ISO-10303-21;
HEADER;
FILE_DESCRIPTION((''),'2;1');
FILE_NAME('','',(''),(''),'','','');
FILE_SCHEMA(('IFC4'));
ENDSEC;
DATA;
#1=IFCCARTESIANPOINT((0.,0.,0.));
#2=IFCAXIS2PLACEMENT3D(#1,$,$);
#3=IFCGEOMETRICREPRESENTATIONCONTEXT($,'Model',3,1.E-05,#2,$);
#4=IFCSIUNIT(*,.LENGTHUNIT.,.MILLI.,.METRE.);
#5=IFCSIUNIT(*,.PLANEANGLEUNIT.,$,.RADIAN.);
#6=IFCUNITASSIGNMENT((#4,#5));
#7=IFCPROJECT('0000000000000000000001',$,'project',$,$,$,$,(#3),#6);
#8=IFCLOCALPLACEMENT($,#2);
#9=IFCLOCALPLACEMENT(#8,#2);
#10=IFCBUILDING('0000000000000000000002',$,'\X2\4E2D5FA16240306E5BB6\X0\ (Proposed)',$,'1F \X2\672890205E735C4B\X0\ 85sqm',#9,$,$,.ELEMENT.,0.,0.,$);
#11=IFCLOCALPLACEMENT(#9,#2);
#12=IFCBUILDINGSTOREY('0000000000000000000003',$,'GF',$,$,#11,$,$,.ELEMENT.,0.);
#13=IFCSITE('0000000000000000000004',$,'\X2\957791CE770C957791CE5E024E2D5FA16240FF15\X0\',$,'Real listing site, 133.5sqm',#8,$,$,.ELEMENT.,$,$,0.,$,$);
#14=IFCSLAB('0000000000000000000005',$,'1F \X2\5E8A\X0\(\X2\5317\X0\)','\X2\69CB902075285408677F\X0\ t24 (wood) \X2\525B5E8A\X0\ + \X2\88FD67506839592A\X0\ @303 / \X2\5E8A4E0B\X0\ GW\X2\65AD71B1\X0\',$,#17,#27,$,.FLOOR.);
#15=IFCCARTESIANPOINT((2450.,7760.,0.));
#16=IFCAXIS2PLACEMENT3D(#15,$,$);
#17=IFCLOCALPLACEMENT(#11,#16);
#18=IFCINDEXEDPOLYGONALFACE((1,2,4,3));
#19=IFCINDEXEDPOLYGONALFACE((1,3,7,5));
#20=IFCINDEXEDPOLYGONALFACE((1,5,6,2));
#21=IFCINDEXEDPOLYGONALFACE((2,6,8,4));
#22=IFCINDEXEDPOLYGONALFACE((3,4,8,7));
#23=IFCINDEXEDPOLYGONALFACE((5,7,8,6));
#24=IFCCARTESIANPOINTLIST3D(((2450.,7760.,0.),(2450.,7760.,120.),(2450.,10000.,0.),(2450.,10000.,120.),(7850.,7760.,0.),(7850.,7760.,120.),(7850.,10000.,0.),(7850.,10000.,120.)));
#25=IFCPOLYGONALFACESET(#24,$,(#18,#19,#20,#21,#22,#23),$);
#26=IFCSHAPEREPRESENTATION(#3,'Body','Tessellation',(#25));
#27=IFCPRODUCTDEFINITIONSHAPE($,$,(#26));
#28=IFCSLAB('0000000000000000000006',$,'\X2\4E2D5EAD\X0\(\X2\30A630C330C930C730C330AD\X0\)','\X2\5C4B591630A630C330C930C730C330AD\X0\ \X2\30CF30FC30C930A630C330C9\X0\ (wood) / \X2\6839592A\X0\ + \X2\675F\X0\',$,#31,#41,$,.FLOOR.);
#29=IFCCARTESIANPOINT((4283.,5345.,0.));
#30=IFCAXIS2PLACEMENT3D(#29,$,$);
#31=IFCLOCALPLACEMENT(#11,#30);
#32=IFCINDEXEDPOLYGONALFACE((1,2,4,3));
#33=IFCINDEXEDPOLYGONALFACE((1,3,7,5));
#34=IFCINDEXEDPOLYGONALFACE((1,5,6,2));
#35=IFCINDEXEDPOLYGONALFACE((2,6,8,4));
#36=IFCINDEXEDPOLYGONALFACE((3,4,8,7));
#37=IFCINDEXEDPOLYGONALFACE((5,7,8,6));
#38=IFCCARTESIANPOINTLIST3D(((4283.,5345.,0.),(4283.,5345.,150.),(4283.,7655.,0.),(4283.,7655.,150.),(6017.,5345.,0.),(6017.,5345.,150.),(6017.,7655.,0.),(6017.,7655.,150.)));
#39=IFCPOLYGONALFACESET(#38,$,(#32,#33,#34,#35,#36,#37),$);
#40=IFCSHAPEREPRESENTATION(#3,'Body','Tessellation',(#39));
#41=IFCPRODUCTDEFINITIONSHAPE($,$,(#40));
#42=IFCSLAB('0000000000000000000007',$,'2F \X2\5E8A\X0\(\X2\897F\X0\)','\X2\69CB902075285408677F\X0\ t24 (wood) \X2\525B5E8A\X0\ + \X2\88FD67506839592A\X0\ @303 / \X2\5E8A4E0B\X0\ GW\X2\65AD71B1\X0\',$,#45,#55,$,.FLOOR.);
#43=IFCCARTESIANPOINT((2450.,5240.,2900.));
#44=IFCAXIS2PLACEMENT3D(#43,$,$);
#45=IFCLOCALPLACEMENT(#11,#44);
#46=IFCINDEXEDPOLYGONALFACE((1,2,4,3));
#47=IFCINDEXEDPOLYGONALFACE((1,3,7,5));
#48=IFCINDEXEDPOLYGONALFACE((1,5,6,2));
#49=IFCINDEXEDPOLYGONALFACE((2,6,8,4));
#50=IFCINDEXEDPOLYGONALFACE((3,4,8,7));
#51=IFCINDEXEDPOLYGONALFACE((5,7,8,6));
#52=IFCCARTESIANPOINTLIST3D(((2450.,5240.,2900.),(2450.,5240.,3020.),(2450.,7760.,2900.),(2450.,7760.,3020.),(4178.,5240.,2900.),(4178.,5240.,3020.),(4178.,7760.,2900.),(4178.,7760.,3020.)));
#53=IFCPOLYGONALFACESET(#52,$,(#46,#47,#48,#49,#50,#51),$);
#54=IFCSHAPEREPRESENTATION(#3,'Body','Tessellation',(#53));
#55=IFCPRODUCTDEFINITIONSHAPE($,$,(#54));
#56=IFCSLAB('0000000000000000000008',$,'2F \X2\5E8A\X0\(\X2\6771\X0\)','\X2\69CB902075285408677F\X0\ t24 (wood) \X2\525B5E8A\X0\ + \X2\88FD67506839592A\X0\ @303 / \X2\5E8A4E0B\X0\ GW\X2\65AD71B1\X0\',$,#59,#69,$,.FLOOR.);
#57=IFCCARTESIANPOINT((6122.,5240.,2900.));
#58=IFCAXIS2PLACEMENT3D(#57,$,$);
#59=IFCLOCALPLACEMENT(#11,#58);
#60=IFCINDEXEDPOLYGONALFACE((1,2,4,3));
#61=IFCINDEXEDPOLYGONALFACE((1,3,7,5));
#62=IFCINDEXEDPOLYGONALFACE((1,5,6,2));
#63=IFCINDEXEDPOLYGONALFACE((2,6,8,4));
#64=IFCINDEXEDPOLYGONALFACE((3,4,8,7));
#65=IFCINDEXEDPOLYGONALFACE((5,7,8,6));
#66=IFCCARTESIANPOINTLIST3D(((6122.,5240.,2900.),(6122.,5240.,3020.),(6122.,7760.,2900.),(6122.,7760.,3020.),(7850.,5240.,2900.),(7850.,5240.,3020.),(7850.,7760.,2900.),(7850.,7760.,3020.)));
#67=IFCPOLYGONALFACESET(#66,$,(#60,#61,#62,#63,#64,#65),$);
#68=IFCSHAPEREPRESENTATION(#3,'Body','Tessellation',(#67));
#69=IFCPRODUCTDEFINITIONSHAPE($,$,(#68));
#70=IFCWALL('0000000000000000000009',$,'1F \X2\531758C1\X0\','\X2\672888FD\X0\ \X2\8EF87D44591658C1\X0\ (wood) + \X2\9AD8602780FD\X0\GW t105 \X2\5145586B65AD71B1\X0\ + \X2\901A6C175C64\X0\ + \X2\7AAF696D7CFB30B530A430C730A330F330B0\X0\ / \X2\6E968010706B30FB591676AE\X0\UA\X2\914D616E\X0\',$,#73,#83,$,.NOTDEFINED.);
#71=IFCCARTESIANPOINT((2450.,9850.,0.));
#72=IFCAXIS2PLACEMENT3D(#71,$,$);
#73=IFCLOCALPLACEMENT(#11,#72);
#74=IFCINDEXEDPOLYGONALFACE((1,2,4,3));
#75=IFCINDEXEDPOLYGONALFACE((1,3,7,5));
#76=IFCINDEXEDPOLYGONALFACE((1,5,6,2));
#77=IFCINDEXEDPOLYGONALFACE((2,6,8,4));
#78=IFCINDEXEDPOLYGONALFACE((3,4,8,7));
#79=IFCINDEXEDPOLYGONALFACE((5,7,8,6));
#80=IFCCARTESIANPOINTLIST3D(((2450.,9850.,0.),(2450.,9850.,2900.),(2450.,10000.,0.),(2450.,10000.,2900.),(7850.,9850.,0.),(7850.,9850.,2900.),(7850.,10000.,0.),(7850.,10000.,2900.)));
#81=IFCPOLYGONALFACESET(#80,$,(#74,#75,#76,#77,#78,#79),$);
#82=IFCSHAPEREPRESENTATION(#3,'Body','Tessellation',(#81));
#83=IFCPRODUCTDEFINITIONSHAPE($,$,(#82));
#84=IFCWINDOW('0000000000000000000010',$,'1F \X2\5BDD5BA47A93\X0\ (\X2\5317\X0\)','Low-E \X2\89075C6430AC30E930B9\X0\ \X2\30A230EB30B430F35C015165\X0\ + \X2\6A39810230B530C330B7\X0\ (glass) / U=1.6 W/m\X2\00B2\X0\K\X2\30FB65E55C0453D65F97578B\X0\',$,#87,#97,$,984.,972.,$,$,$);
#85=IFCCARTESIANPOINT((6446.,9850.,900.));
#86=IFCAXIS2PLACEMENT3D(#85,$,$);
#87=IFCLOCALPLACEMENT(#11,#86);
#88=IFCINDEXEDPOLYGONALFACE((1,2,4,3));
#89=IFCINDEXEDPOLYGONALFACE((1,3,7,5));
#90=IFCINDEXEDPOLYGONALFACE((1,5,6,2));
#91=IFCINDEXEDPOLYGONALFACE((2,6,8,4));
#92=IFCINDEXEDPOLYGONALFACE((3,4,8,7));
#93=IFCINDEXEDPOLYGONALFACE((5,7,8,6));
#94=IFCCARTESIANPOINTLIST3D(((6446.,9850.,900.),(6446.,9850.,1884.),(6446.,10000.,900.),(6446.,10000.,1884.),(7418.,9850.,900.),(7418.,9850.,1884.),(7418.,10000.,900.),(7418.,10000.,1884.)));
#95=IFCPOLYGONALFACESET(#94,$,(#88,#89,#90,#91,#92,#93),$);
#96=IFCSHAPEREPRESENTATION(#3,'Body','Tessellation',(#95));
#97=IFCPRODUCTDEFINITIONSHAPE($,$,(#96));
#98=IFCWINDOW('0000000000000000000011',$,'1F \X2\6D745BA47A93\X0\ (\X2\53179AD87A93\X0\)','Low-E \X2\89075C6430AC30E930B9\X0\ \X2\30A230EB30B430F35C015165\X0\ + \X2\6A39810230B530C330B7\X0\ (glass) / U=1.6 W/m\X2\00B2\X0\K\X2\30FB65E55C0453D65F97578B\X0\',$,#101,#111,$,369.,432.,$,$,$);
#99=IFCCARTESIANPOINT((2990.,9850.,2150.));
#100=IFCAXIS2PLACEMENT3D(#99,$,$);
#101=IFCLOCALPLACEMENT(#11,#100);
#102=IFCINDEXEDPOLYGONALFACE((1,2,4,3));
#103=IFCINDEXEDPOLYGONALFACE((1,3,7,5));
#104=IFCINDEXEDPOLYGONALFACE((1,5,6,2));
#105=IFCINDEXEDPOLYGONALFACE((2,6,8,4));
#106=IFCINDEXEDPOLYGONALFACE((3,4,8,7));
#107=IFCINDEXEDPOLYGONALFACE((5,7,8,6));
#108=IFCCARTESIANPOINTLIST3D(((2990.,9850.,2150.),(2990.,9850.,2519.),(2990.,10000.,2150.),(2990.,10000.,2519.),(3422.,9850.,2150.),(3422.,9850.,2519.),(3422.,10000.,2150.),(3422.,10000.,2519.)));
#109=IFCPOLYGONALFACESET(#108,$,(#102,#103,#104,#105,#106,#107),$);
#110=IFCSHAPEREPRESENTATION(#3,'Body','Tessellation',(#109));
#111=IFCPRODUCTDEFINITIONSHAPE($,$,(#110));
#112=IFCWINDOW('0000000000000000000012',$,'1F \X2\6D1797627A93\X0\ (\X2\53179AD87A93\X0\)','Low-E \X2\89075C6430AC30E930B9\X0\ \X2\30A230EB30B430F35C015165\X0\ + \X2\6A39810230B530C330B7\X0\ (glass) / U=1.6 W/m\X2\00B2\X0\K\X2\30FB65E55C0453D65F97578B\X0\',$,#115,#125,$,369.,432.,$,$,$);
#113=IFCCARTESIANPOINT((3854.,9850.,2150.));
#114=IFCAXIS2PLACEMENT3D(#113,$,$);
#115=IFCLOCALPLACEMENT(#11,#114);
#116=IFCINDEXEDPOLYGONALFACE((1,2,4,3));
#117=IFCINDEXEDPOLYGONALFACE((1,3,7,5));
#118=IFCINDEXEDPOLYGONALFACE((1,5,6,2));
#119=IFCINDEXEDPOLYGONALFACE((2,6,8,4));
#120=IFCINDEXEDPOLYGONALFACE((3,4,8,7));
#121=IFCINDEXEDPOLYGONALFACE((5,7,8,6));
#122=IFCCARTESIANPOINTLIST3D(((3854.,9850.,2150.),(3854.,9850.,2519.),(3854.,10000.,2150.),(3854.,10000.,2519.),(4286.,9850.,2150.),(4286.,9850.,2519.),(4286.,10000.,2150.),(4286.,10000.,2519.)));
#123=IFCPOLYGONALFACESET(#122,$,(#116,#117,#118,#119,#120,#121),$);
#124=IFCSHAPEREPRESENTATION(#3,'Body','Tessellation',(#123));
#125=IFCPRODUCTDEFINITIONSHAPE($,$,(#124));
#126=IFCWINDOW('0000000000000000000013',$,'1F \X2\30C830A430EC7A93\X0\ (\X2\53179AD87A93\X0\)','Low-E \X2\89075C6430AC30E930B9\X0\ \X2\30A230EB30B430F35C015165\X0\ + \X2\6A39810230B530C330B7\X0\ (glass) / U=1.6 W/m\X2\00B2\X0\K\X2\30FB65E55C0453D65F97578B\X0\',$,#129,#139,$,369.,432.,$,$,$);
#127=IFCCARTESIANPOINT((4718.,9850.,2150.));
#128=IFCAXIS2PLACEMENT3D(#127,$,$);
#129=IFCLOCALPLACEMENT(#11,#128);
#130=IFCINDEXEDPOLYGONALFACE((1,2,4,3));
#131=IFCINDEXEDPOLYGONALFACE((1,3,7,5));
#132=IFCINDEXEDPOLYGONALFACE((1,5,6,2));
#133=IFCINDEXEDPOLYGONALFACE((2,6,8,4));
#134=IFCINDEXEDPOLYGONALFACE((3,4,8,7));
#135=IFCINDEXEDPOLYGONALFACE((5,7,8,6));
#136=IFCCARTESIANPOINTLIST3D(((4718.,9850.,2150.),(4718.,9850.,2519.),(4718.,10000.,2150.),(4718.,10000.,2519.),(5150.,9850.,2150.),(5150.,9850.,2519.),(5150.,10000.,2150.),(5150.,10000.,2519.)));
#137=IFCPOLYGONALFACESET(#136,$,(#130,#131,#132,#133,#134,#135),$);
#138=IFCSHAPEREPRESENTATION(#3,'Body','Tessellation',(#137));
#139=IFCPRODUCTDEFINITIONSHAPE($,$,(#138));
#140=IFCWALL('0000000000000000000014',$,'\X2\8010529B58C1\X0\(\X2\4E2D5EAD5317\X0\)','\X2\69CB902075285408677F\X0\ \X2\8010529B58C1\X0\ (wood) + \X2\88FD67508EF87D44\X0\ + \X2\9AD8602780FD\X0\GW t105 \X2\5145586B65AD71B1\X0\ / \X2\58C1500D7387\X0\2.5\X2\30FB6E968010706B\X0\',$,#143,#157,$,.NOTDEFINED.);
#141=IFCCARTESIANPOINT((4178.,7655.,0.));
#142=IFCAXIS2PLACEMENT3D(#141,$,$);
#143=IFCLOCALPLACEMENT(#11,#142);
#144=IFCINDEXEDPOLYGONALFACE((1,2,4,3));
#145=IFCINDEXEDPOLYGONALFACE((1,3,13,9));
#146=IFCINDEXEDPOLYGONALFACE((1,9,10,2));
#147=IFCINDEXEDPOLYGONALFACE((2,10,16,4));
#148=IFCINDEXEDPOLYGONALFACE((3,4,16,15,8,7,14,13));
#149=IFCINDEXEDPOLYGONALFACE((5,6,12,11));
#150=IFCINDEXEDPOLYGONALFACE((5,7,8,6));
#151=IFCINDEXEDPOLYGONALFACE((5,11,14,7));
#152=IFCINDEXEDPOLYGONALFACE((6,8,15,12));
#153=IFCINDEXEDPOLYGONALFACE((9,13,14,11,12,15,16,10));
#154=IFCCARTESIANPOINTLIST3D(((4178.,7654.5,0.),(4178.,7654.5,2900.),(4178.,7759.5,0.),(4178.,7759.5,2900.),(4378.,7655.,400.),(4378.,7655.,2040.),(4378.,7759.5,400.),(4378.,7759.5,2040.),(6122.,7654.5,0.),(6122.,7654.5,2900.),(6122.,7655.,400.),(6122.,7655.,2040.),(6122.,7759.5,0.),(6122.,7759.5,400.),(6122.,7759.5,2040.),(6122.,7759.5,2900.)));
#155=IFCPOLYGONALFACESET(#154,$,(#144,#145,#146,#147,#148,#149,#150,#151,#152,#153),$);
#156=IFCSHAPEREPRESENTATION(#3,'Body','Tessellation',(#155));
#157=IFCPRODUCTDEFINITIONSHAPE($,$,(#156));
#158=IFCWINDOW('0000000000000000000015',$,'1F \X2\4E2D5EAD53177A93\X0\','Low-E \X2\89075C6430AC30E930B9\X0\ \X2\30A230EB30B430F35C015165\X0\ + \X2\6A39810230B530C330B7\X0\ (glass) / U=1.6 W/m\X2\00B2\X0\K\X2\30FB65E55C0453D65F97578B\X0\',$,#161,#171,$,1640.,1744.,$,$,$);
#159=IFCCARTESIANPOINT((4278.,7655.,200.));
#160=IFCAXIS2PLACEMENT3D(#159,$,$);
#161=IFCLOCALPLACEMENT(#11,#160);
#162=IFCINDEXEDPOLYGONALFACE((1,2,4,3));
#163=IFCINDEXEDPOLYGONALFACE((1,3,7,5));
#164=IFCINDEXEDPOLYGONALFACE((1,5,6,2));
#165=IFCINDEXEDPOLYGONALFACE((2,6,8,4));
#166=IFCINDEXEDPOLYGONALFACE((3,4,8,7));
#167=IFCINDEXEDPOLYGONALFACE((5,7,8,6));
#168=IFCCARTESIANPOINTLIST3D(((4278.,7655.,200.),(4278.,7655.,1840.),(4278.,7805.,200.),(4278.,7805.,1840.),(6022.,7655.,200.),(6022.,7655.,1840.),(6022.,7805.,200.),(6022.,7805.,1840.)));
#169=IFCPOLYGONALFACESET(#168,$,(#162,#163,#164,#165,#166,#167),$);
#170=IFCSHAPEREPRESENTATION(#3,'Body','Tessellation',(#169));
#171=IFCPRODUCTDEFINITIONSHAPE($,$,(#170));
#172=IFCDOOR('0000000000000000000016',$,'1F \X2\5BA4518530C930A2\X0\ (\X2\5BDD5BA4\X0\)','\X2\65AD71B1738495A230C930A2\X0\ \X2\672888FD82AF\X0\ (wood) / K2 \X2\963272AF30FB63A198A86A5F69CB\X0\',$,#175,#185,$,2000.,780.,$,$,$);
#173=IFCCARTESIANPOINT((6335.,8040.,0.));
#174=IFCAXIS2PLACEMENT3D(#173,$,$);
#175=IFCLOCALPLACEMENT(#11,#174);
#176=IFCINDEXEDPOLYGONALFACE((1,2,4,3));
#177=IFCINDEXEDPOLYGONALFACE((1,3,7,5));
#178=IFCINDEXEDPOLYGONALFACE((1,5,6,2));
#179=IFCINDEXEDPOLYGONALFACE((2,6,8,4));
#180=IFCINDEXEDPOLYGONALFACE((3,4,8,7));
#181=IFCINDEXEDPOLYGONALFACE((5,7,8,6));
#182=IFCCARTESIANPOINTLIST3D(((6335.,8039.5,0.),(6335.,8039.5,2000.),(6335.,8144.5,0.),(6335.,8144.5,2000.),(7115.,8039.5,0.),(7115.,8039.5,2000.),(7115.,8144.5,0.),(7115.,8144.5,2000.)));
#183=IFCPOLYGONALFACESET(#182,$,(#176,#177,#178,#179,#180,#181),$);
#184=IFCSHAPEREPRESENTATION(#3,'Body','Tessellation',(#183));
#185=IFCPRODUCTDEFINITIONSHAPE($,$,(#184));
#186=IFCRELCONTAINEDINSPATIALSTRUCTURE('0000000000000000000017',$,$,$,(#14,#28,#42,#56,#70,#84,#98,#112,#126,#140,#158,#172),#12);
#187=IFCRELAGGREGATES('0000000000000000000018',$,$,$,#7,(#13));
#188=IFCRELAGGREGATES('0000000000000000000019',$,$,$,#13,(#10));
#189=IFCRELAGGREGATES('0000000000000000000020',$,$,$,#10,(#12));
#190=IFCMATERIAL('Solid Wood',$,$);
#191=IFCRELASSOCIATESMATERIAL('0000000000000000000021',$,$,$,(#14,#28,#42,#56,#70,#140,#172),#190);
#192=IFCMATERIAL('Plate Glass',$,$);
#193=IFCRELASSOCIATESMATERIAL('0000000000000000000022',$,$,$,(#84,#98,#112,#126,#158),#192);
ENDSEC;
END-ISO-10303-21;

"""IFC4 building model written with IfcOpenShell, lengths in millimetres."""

from ifc_helpers import new_model, si_unit, frame, frame_2d, origin, place, context, project, spatial, rectangle, extrude, material, element, fill, save


model = new_model("IFC4")

# Units and contexts
model_context = context("Model", 3, precision=1e-05, world=origin())
ifc_project = project(units=[si_unit("LENGTHUNIT", "METRE", prefix="MILLI"), si_unit("PLANEANGLEUNIT", "RADIAN")], contexts=[model_context])

# Site, building, storey
site_placement = place(None, origin())
site = spatial("IfcSite", under=ifc_project, at=site_placement, Name="長野県長野市中御所５", ObjectType="Real listing site, 133.5sqm", CompositionType="ELEMENT", RefElevation=0.0)
building_placement = place(site_placement, origin())
building = spatial("IfcBuilding", under=site, at=building_placement, Name="中御所の家 (Proposed)", ObjectType="1F 木造平屋 85sqm", CompositionType="ELEMENT", ElevationOfRefHeight=0.0, ElevationOfTerrain=0.0)
storey_placement = place(building_placement, origin())
storey = spatial("IfcBuildingStorey", under=building, at=storey_placement, Name="GF", CompositionType="ELEMENT", Elevation=0.0)

# Slabs
ifc_material_1 = material(Name="Solid Wood")
slab_1_placement = place(storey_placement, frame((2450.0, 7760.0, 0.0)))
element("IfcSlab", 1, at=slab_1_placement, inside=storey, material=ifc_material_1, Name="1F 床(北)", Description="構造用合板 t24 (wood) 剛床 + 製材根太 @303 / 床下 GW断熱", PredefinedType="FLOOR", context=model_context, shape_type="SweptSolid", body=[
    extrude(rectangle(XDim=5400.0, YDim=2240.0, at=frame_2d((2700.0, 1120.0))), frame((2450.0, 7760.0, 0.0)), (0.0, 0.0, 1.0), 120.0),
])
slab_2_placement = place(storey_placement, frame((4283.0, 5345.0, 0.0)))
element("IfcSlab", 2, at=slab_2_placement, inside=storey, material=ifc_material_1, Name="中庭(ウッドデッキ)", Description="屋外ウッドデッキ ハードウッド (wood) / 根太 + 束", PredefinedType="FLOOR", context=model_context, shape_type="SweptSolid", body=[
    extrude(rectangle(XDim=1734.0, YDim=2310.0, at=frame_2d((867.0, 1155.0))), frame((4283.0, 5345.0, 0.0)), (0.0, 0.0, 1.0), 150.0),
])
slab_3_placement = place(storey_placement, frame((2450.0, 5240.0, 2900.0)))
element("IfcSlab", 3, at=slab_3_placement, inside=storey, material=ifc_material_1, Name="2F 床(西)", Description="構造用合板 t24 (wood) 剛床 + 製材根太 @303 / 床下 GW断熱", PredefinedType="FLOOR", context=model_context, shape_type="SweptSolid", body=[
    extrude(rectangle(XDim=1728.0, YDim=2520.0, at=frame_2d((864.0, 1260.0))), frame((2450.0, 5240.0, 2900.0)), (0.0, 0.0, 1.0), 120.0),
])
slab_4_placement = place(storey_placement, frame((6122.0, 5240.0, 2900.0)))
element("IfcSlab", 4, at=slab_4_placement, inside=storey, material=ifc_material_1, Name="2F 床(東)", Description="構造用合板 t24 (wood) 剛床 + 製材根太 @303 / 床下 GW断熱", PredefinedType="FLOOR", context=model_context, shape_type="SweptSolid", body=[
    extrude(rectangle(XDim=1728.0, YDim=2520.0, at=frame_2d((864.0, 1260.0))), frame((6122.0, 5240.0, 2900.0)), (0.0, 0.0, 1.0), 120.0),
])

# Wall, openings, windows
wall_1_placement = place(storey_placement, frame((2450.0, 9850.0, 0.0)))
wall_1 = element("IfcWall", 5, at=wall_1_placement, inside=storey, material=ifc_material_1, Name="1F 北壁", Description="木製 軸組外壁 (wood) + 高性能GW t105 充填断熱 + 通気層 + 窯業系サイディング / 準耐火・外皮UA配慮", PredefinedType="NOTDEFINED", context=model_context, shape_type="SweptSolid", body=[
    extrude(rectangle(XDim=5400.0, YDim=150.0, at=frame_2d((2700.0, 75.0))), frame((2450.0, 9850.0, 0.0)), (0.0, 0.0, 1.0), 2900.0),
])
opening_1_placement = place(storey_placement, frame((6446.0, 9850.0, 900.0)))
opening_1 = element("IfcOpeningElement", 6, at=opening_1_placement, cuts=wall_1, PredefinedType="NOTDEFINED", context=model_context, shape_type="SweptSolid", body=[
    extrude(rectangle(XDim=972.0, YDim=150.0, at=frame_2d((486.0, 75.0))), frame((6446.0, 9850.0, 900.0)), (0.0, 0.0, 1.0), 984.0),
])
opening_2_placement = place(storey_placement, frame((2990.0, 9850.0, 2150.0)))
opening_2 = element("IfcOpeningElement", 7, at=opening_2_placement, cuts=wall_1, PredefinedType="NOTDEFINED", context=model_context, shape_type="SweptSolid", body=[
    extrude(rectangle(XDim=432.0, YDim=150.0, at=frame_2d((216.0, 75.0))), frame((2990.0, 9850.0, 2150.0)), (0.0, 0.0, 1.0), 369.0),
])
opening_3_placement = place(storey_placement, frame((3854.0, 9850.0, 2150.0)))
opening_3 = element("IfcOpeningElement", 8, at=opening_3_placement, cuts=wall_1, PredefinedType="NOTDEFINED", context=model_context, shape_type="SweptSolid", body=[
    extrude(rectangle(XDim=432.0, YDim=150.0, at=frame_2d((216.0, 75.0))), frame((3854.0, 9850.0, 2150.0)), (0.0, 0.0, 1.0), 369.0),
])
opening_4_placement = place(storey_placement, frame((4718.0, 9850.0, 2150.0)))
opening_4 = element("IfcOpeningElement", 9, at=opening_4_placement, cuts=wall_1, PredefinedType="NOTDEFINED", context=model_context, shape_type="SweptSolid", body=[
    extrude(rectangle(XDim=432.0, YDim=150.0, at=frame_2d((216.0, 75.0))), frame((4718.0, 9850.0, 2150.0)), (0.0, 0.0, 1.0), 369.0),
])
ifc_material_2 = material(Name="Plate Glass")
window_1_placement = place(storey_placement, frame((6446.0, 9850.0, 900.0)))
window_1 = element("IfcWindow", 10, at=window_1_placement, inside=storey, material=ifc_material_2, Name="1F 寝室窓 (北)", Description="Low-E 複層ガラス アルゴン封入 + 樹脂サッシ (glass) / U=1.6 W/m²K・日射取得型", OverallHeight=984.0, OverallWidth=972.0, context=model_context, shape_type="SweptSolid", body=[
    extrude(rectangle(XDim=972.0, YDim=150.0, at=frame_2d((486.0, 75.0))), frame((6446.0, 9850.0, 900.0)), (0.0, 0.0, 1.0), 984.0),
])
fill(opening_1, window_1)
window_2_placement = place(storey_placement, frame((2990.0, 9850.0, 2150.0)))
window_2 = element("IfcWindow", 11, at=window_2_placement, inside=storey, material=ifc_material_2, Name="1F 浴室窓 (北高窓)", Description="Low-E 複層ガラス アルゴン封入 + 樹脂サッシ (glass) / U=1.6 W/m²K・日射取得型", OverallHeight=369.0, OverallWidth=432.0, context=model_context, shape_type="SweptSolid", body=[
    extrude(rectangle(XDim=432.0, YDim=150.0, at=frame_2d((216.0, 75.0))), frame((2990.0, 9850.0, 2150.0)), (0.0, 0.0, 1.0), 369.0),
])
fill(opening_2, window_2)
window_3_placement = place(storey_placement, frame((3854.0, 9850.0, 2150.0)))
window_3 = element("IfcWindow", 12, at=window_3_placement, inside=storey, material=ifc_material_2, Name="1F 洗面窓 (北高窓)", Description="Low-E 複層ガラス アルゴン封入 + 樹脂サッシ (glass) / U=1.6 W/m²K・日射取得型", OverallHeight=369.0, OverallWidth=432.0, context=model_context, shape_type="SweptSolid", body=[
    extrude(rectangle(XDim=432.0, YDim=150.0, at=frame_2d((216.0, 75.0))), frame((3854.0, 9850.0, 2150.0)), (0.0, 0.0, 1.0), 369.0),
])
fill(opening_3, window_3)
window_4_placement = place(storey_placement, frame((4718.0, 9850.0, 2150.0)))
window_4 = element("IfcWindow", 13, at=window_4_placement, inside=storey, material=ifc_material_2, Name="1F トイレ窓 (北高窓)", Description="Low-E 複層ガラス アルゴン封入 + 樹脂サッシ (glass) / U=1.6 W/m²K・日射取得型", OverallHeight=369.0, OverallWidth=432.0, context=model_context, shape_type="SweptSolid", body=[
    extrude(rectangle(XDim=432.0, YDim=150.0, at=frame_2d((216.0, 75.0))), frame((4718.0, 9850.0, 2150.0)), (0.0, 0.0, 1.0), 369.0),
])
fill(opening_4, window_4)

# Wall, opening, window
wall_2_placement = place(storey_placement, frame((4178.0, 7655.0, 0.0)))
wall_2 = element("IfcWall", 14, at=wall_2_placement, inside=storey, material=ifc_material_1, Name="耐力壁(中庭北)", Description="構造用合板 耐力壁 (wood) + 製材軸組 + 高性能GW t105 充填断熱 / 壁倍率2.5・準耐火", PredefinedType="NOTDEFINED", context=model_context, shape_type="SweptSolid", body=[
    extrude(rectangle(XDim=1944.0, YDim=105.0, at=frame_2d((972.0, 52.0))), frame((4178.0, 7655.0, 0.0)), (0.0, 0.0, 1.0), 2900.0),
])
opening_5_placement = place(storey_placement, frame((4278.0, 7655.0, 200.0)))
opening_5 = element("IfcOpeningElement", 15, at=opening_5_placement, cuts=wall_2, PredefinedType="NOTDEFINED", context=model_context, shape_type="SweptSolid", body=[
    extrude(rectangle(XDim=1744.0, YDim=150.0, at=frame_2d((872.0, 75.0))), frame((4278.0, 7655.0, 200.0)), (0.0, 0.0, 1.0), 1640.0),
])
window_5_placement = place(storey_placement, frame((4278.0, 7655.0, 200.0)))
window_5 = element("IfcWindow", 16, at=window_5_placement, inside=storey, material=ifc_material_2, Name="1F 中庭北窓", Description="Low-E 複層ガラス アルゴン封入 + 樹脂サッシ (glass) / U=1.6 W/m²K・日射取得型", OverallHeight=1640.0, OverallWidth=1744.0, context=model_context, shape_type="SweptSolid", body=[
    extrude(rectangle(XDim=1744.0, YDim=150.0, at=frame_2d((872.0, 75.0))), frame((4278.0, 7655.0, 200.0)), (0.0, 0.0, 1.0), 1640.0),
])
fill(opening_5, window_5)

# Door
door_1_placement = place(storey_placement, frame((6335.0, 8040.0, 0.0)))
element("IfcDoor", 17, at=door_1_placement, inside=storey, material=ifc_material_1, Name="1F 室内ドア (寝室)", Description="断熱玄関ドア 木製芯 (wood) / K2 防犯・採風機構", OverallHeight=2000.0, OverallWidth=780.0, context=model_context, shape_type="SweptSolid", body=[
    extrude(rectangle(XDim=780.0, YDim=105.0, at=frame_2d((390.0, 52.0))), frame((6335.0, 8040.0, 0.0)), (0.0, 0.0, 1.0), 2000.0),
])

save(model, "model.ifc")
